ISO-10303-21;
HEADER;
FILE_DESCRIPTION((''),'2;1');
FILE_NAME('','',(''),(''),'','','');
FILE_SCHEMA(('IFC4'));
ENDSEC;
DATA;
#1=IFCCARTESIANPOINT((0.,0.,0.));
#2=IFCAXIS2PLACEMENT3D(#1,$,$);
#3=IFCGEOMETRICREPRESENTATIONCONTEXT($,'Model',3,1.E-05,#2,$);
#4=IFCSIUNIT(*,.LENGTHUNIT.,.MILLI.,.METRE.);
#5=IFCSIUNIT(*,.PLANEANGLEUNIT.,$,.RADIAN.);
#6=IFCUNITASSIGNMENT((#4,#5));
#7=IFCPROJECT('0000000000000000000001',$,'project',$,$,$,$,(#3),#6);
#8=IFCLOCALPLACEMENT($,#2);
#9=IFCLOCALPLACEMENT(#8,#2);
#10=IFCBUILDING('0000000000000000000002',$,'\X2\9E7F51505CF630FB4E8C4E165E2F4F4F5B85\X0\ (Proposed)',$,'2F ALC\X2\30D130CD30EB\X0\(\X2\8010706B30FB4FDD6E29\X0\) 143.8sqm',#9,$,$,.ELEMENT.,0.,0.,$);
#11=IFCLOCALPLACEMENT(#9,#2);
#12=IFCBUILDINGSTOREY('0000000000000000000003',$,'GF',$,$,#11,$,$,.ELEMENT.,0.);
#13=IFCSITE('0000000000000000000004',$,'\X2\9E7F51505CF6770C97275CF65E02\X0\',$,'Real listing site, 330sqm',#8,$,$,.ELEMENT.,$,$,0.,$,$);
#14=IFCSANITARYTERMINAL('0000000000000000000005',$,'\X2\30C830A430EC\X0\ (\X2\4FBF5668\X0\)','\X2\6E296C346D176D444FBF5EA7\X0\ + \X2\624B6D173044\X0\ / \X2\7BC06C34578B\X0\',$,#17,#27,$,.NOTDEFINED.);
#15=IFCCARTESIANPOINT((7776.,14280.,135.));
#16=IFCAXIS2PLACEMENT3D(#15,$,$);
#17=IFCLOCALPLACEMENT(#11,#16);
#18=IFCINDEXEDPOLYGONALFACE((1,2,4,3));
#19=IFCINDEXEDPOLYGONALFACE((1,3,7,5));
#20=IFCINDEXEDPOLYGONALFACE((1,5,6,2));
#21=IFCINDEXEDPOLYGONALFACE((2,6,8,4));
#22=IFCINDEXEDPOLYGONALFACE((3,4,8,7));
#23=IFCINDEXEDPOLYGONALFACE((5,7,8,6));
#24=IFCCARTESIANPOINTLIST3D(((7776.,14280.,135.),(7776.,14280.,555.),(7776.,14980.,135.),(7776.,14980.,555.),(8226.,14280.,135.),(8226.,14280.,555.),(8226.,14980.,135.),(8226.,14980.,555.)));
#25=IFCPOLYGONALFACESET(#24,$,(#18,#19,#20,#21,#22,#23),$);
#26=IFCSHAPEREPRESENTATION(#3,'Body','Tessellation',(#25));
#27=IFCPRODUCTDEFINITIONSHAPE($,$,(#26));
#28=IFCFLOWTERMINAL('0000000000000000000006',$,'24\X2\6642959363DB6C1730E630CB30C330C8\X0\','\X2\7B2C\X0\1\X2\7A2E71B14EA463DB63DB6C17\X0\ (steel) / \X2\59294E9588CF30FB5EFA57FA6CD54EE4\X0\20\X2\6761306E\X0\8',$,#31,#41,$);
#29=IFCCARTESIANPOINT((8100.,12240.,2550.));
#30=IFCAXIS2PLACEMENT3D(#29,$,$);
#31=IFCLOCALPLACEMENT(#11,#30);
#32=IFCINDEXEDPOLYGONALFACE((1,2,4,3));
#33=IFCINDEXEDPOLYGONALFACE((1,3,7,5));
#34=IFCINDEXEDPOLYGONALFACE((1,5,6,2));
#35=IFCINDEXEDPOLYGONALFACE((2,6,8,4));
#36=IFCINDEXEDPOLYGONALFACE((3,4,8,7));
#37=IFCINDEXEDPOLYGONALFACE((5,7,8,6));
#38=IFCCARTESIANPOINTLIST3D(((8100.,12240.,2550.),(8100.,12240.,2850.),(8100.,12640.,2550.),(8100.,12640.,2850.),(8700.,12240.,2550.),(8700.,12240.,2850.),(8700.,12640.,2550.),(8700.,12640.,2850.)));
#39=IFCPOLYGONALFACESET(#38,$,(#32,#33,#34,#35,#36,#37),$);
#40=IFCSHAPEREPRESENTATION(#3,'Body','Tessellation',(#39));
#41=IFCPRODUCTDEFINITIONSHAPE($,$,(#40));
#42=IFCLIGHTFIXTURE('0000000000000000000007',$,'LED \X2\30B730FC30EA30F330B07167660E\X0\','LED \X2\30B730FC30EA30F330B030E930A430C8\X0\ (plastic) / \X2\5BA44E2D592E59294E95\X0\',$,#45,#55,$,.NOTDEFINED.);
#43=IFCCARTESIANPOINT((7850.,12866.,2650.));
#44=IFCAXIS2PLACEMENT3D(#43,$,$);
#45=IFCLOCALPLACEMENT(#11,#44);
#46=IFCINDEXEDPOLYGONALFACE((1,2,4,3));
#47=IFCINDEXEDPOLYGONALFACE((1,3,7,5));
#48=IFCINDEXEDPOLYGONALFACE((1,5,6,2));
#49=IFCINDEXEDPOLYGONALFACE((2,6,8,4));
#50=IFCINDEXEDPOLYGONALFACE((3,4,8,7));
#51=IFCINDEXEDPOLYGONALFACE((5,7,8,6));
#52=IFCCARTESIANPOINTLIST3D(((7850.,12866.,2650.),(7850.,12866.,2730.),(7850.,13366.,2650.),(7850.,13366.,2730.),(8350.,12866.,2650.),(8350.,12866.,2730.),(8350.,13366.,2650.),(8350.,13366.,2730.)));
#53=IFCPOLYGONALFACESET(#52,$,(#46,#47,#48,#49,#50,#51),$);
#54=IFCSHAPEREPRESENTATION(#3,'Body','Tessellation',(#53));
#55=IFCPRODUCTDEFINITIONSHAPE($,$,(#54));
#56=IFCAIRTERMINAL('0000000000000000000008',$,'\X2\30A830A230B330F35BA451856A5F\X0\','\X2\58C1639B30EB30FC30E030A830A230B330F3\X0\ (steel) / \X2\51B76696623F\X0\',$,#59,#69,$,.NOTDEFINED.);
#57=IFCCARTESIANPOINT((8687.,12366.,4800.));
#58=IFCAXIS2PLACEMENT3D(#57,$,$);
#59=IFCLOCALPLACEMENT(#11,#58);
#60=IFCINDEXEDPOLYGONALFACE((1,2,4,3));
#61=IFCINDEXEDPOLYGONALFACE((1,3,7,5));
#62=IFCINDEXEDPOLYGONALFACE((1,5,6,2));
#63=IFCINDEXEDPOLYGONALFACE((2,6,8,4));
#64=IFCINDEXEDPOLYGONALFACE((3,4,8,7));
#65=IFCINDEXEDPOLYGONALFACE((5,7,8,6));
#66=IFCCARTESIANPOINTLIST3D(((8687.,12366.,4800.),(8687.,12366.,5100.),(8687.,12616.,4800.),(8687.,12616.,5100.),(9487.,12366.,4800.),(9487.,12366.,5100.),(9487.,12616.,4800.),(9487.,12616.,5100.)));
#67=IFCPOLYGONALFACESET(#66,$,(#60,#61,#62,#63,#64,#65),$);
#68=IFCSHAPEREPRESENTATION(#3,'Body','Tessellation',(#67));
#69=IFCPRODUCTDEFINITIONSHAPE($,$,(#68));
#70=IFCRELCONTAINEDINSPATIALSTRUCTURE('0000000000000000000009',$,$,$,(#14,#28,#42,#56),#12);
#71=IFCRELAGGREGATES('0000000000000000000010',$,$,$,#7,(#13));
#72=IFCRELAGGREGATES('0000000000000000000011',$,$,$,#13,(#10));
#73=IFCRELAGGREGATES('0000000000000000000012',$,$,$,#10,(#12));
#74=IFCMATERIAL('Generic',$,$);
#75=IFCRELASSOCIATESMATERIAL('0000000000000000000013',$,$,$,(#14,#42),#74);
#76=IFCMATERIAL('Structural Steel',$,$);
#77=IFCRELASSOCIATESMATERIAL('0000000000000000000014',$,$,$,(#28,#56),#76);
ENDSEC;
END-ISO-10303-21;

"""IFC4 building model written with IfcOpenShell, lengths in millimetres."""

from ifc_helpers import new_model, si_unit, frame, frame_2d, origin, place, context, project, spatial, rectangle, extrude, material, element, save


model = new_model("IFC4")

# Units and contexts
model_context = context("Model", 3, precision=1e-05, world=origin())
ifc_project = project(units=[si_unit("LENGTHUNIT", "METRE", prefix="MILLI"), si_unit("PLANEANGLEUNIT", "RADIAN")], contexts=[model_context])

# Site, building, storey
site_placement = place(None, origin())
site = spatial("IfcSite", under=ifc_project, at=site_placement, Name="鹿児島県霧島市", ObjectType="Real listing site, 330sqm", CompositionType="ELEMENT", RefElevation=0.0)
building_placement = place(site_placement, origin())
building = spatial("IfcBuilding", under=site, at=building_placement, Name="鹿児島・二世帯住宅 (Proposed)", ObjectType="2F ALCパネル(耐火・保温) 143.8sqm", CompositionType="ELEMENT", ElevationOfRefHeight=0.0, ElevationOfTerrain=0.0)
storey_placement = place(building_placement, origin())
storey = spatial("IfcBuildingStorey", under=building, at=storey_placement, Name="GF", CompositionType="ELEMENT", Elevation=0.0)

# Sanitary terminal
ifc_material_1 = material(Name="Generic")
sanitary_terminal_placement = place(storey_placement, frame((7776.0, 14280.0, 135.0)))
element("IfcSanitaryTerminal", 1, at=sanitary_terminal_placement, inside=storey, material=ifc_material_1, Name="トイレ (便器)", Description="温水洗浄便座 + 手洗い / 節水型", PredefinedType="NOTDEFINED", context=model_context, shape_type="SweptSolid", body=[
    extrude(rectangle(XDim=450.0, YDim=700.0, at=frame_2d((225.0, 350.0))), frame((7776.0, 14280.0, 135.0)), (0.0, 0.0, 1.0), 420.0),
])

# Flow terminal
ifc_material_2 = material(Name="Structural Steel")
flow_terminal_placement = place(storey_placement, frame((8100.0, 12240.0, 2550.0)))
element("IfcFlowTerminal", 2, at=flow_terminal_placement, inside=storey, material=ifc_material_2, Name="24時間換気ユニット", Description="第1種熱交換換気 (steel) / 天井裏・建基法令20条の8", context=model_context, shape_type="SweptSolid", body=[
    extrude(rectangle(XDim=600.0, YDim=400.0, at=frame_2d((300.0, 200.0))), frame((8100.0, 12240.0, 2550.0)), (0.0, 0.0, 1.0), 300.0),
])

# Light fixture
light_fixture_placement = place(storey_placement, frame((7850.0, 12866.0, 2650.0)))
element("IfcLightFixture", 3, at=light_fixture_placement, inside=storey, material=ifc_material_1, Name="LED シーリング照明", Description="LED シーリングライト (plastic) / 室中央天井", PredefinedType="NOTDEFINED", context=model_context, shape_type="SweptSolid", body=[
    extrude(rectangle(XDim=500.0, YDim=500.0, at=frame_2d((250.0, 250.0))), frame((7850.0, 12866.0, 2650.0)), (0.0, 0.0, 1.0), 80.0),
])

# Air terminal
air_terminal_placement = place(storey_placement, frame((8687.0, 12366.0, 4800.0)))
element("IfcAirTerminal", 4, at=air_terminal_placement, inside=storey, material=ifc_material_2, Name="エアコン室内機", Description="壁掛ルームエアコン (steel) / 冷暖房", PredefinedType="NOTDEFINED", context=model_context, shape_type="SweptSolid", body=[
    extrude(rectangle(XDim=800.0, YDim=250.0, at=frame_2d((400.0, 125.0))), frame((8687.0, 12366.0, 4800.0)), (0.0, 0.0, 1.0), 300.0),
])

save(model, "model.ifc")
